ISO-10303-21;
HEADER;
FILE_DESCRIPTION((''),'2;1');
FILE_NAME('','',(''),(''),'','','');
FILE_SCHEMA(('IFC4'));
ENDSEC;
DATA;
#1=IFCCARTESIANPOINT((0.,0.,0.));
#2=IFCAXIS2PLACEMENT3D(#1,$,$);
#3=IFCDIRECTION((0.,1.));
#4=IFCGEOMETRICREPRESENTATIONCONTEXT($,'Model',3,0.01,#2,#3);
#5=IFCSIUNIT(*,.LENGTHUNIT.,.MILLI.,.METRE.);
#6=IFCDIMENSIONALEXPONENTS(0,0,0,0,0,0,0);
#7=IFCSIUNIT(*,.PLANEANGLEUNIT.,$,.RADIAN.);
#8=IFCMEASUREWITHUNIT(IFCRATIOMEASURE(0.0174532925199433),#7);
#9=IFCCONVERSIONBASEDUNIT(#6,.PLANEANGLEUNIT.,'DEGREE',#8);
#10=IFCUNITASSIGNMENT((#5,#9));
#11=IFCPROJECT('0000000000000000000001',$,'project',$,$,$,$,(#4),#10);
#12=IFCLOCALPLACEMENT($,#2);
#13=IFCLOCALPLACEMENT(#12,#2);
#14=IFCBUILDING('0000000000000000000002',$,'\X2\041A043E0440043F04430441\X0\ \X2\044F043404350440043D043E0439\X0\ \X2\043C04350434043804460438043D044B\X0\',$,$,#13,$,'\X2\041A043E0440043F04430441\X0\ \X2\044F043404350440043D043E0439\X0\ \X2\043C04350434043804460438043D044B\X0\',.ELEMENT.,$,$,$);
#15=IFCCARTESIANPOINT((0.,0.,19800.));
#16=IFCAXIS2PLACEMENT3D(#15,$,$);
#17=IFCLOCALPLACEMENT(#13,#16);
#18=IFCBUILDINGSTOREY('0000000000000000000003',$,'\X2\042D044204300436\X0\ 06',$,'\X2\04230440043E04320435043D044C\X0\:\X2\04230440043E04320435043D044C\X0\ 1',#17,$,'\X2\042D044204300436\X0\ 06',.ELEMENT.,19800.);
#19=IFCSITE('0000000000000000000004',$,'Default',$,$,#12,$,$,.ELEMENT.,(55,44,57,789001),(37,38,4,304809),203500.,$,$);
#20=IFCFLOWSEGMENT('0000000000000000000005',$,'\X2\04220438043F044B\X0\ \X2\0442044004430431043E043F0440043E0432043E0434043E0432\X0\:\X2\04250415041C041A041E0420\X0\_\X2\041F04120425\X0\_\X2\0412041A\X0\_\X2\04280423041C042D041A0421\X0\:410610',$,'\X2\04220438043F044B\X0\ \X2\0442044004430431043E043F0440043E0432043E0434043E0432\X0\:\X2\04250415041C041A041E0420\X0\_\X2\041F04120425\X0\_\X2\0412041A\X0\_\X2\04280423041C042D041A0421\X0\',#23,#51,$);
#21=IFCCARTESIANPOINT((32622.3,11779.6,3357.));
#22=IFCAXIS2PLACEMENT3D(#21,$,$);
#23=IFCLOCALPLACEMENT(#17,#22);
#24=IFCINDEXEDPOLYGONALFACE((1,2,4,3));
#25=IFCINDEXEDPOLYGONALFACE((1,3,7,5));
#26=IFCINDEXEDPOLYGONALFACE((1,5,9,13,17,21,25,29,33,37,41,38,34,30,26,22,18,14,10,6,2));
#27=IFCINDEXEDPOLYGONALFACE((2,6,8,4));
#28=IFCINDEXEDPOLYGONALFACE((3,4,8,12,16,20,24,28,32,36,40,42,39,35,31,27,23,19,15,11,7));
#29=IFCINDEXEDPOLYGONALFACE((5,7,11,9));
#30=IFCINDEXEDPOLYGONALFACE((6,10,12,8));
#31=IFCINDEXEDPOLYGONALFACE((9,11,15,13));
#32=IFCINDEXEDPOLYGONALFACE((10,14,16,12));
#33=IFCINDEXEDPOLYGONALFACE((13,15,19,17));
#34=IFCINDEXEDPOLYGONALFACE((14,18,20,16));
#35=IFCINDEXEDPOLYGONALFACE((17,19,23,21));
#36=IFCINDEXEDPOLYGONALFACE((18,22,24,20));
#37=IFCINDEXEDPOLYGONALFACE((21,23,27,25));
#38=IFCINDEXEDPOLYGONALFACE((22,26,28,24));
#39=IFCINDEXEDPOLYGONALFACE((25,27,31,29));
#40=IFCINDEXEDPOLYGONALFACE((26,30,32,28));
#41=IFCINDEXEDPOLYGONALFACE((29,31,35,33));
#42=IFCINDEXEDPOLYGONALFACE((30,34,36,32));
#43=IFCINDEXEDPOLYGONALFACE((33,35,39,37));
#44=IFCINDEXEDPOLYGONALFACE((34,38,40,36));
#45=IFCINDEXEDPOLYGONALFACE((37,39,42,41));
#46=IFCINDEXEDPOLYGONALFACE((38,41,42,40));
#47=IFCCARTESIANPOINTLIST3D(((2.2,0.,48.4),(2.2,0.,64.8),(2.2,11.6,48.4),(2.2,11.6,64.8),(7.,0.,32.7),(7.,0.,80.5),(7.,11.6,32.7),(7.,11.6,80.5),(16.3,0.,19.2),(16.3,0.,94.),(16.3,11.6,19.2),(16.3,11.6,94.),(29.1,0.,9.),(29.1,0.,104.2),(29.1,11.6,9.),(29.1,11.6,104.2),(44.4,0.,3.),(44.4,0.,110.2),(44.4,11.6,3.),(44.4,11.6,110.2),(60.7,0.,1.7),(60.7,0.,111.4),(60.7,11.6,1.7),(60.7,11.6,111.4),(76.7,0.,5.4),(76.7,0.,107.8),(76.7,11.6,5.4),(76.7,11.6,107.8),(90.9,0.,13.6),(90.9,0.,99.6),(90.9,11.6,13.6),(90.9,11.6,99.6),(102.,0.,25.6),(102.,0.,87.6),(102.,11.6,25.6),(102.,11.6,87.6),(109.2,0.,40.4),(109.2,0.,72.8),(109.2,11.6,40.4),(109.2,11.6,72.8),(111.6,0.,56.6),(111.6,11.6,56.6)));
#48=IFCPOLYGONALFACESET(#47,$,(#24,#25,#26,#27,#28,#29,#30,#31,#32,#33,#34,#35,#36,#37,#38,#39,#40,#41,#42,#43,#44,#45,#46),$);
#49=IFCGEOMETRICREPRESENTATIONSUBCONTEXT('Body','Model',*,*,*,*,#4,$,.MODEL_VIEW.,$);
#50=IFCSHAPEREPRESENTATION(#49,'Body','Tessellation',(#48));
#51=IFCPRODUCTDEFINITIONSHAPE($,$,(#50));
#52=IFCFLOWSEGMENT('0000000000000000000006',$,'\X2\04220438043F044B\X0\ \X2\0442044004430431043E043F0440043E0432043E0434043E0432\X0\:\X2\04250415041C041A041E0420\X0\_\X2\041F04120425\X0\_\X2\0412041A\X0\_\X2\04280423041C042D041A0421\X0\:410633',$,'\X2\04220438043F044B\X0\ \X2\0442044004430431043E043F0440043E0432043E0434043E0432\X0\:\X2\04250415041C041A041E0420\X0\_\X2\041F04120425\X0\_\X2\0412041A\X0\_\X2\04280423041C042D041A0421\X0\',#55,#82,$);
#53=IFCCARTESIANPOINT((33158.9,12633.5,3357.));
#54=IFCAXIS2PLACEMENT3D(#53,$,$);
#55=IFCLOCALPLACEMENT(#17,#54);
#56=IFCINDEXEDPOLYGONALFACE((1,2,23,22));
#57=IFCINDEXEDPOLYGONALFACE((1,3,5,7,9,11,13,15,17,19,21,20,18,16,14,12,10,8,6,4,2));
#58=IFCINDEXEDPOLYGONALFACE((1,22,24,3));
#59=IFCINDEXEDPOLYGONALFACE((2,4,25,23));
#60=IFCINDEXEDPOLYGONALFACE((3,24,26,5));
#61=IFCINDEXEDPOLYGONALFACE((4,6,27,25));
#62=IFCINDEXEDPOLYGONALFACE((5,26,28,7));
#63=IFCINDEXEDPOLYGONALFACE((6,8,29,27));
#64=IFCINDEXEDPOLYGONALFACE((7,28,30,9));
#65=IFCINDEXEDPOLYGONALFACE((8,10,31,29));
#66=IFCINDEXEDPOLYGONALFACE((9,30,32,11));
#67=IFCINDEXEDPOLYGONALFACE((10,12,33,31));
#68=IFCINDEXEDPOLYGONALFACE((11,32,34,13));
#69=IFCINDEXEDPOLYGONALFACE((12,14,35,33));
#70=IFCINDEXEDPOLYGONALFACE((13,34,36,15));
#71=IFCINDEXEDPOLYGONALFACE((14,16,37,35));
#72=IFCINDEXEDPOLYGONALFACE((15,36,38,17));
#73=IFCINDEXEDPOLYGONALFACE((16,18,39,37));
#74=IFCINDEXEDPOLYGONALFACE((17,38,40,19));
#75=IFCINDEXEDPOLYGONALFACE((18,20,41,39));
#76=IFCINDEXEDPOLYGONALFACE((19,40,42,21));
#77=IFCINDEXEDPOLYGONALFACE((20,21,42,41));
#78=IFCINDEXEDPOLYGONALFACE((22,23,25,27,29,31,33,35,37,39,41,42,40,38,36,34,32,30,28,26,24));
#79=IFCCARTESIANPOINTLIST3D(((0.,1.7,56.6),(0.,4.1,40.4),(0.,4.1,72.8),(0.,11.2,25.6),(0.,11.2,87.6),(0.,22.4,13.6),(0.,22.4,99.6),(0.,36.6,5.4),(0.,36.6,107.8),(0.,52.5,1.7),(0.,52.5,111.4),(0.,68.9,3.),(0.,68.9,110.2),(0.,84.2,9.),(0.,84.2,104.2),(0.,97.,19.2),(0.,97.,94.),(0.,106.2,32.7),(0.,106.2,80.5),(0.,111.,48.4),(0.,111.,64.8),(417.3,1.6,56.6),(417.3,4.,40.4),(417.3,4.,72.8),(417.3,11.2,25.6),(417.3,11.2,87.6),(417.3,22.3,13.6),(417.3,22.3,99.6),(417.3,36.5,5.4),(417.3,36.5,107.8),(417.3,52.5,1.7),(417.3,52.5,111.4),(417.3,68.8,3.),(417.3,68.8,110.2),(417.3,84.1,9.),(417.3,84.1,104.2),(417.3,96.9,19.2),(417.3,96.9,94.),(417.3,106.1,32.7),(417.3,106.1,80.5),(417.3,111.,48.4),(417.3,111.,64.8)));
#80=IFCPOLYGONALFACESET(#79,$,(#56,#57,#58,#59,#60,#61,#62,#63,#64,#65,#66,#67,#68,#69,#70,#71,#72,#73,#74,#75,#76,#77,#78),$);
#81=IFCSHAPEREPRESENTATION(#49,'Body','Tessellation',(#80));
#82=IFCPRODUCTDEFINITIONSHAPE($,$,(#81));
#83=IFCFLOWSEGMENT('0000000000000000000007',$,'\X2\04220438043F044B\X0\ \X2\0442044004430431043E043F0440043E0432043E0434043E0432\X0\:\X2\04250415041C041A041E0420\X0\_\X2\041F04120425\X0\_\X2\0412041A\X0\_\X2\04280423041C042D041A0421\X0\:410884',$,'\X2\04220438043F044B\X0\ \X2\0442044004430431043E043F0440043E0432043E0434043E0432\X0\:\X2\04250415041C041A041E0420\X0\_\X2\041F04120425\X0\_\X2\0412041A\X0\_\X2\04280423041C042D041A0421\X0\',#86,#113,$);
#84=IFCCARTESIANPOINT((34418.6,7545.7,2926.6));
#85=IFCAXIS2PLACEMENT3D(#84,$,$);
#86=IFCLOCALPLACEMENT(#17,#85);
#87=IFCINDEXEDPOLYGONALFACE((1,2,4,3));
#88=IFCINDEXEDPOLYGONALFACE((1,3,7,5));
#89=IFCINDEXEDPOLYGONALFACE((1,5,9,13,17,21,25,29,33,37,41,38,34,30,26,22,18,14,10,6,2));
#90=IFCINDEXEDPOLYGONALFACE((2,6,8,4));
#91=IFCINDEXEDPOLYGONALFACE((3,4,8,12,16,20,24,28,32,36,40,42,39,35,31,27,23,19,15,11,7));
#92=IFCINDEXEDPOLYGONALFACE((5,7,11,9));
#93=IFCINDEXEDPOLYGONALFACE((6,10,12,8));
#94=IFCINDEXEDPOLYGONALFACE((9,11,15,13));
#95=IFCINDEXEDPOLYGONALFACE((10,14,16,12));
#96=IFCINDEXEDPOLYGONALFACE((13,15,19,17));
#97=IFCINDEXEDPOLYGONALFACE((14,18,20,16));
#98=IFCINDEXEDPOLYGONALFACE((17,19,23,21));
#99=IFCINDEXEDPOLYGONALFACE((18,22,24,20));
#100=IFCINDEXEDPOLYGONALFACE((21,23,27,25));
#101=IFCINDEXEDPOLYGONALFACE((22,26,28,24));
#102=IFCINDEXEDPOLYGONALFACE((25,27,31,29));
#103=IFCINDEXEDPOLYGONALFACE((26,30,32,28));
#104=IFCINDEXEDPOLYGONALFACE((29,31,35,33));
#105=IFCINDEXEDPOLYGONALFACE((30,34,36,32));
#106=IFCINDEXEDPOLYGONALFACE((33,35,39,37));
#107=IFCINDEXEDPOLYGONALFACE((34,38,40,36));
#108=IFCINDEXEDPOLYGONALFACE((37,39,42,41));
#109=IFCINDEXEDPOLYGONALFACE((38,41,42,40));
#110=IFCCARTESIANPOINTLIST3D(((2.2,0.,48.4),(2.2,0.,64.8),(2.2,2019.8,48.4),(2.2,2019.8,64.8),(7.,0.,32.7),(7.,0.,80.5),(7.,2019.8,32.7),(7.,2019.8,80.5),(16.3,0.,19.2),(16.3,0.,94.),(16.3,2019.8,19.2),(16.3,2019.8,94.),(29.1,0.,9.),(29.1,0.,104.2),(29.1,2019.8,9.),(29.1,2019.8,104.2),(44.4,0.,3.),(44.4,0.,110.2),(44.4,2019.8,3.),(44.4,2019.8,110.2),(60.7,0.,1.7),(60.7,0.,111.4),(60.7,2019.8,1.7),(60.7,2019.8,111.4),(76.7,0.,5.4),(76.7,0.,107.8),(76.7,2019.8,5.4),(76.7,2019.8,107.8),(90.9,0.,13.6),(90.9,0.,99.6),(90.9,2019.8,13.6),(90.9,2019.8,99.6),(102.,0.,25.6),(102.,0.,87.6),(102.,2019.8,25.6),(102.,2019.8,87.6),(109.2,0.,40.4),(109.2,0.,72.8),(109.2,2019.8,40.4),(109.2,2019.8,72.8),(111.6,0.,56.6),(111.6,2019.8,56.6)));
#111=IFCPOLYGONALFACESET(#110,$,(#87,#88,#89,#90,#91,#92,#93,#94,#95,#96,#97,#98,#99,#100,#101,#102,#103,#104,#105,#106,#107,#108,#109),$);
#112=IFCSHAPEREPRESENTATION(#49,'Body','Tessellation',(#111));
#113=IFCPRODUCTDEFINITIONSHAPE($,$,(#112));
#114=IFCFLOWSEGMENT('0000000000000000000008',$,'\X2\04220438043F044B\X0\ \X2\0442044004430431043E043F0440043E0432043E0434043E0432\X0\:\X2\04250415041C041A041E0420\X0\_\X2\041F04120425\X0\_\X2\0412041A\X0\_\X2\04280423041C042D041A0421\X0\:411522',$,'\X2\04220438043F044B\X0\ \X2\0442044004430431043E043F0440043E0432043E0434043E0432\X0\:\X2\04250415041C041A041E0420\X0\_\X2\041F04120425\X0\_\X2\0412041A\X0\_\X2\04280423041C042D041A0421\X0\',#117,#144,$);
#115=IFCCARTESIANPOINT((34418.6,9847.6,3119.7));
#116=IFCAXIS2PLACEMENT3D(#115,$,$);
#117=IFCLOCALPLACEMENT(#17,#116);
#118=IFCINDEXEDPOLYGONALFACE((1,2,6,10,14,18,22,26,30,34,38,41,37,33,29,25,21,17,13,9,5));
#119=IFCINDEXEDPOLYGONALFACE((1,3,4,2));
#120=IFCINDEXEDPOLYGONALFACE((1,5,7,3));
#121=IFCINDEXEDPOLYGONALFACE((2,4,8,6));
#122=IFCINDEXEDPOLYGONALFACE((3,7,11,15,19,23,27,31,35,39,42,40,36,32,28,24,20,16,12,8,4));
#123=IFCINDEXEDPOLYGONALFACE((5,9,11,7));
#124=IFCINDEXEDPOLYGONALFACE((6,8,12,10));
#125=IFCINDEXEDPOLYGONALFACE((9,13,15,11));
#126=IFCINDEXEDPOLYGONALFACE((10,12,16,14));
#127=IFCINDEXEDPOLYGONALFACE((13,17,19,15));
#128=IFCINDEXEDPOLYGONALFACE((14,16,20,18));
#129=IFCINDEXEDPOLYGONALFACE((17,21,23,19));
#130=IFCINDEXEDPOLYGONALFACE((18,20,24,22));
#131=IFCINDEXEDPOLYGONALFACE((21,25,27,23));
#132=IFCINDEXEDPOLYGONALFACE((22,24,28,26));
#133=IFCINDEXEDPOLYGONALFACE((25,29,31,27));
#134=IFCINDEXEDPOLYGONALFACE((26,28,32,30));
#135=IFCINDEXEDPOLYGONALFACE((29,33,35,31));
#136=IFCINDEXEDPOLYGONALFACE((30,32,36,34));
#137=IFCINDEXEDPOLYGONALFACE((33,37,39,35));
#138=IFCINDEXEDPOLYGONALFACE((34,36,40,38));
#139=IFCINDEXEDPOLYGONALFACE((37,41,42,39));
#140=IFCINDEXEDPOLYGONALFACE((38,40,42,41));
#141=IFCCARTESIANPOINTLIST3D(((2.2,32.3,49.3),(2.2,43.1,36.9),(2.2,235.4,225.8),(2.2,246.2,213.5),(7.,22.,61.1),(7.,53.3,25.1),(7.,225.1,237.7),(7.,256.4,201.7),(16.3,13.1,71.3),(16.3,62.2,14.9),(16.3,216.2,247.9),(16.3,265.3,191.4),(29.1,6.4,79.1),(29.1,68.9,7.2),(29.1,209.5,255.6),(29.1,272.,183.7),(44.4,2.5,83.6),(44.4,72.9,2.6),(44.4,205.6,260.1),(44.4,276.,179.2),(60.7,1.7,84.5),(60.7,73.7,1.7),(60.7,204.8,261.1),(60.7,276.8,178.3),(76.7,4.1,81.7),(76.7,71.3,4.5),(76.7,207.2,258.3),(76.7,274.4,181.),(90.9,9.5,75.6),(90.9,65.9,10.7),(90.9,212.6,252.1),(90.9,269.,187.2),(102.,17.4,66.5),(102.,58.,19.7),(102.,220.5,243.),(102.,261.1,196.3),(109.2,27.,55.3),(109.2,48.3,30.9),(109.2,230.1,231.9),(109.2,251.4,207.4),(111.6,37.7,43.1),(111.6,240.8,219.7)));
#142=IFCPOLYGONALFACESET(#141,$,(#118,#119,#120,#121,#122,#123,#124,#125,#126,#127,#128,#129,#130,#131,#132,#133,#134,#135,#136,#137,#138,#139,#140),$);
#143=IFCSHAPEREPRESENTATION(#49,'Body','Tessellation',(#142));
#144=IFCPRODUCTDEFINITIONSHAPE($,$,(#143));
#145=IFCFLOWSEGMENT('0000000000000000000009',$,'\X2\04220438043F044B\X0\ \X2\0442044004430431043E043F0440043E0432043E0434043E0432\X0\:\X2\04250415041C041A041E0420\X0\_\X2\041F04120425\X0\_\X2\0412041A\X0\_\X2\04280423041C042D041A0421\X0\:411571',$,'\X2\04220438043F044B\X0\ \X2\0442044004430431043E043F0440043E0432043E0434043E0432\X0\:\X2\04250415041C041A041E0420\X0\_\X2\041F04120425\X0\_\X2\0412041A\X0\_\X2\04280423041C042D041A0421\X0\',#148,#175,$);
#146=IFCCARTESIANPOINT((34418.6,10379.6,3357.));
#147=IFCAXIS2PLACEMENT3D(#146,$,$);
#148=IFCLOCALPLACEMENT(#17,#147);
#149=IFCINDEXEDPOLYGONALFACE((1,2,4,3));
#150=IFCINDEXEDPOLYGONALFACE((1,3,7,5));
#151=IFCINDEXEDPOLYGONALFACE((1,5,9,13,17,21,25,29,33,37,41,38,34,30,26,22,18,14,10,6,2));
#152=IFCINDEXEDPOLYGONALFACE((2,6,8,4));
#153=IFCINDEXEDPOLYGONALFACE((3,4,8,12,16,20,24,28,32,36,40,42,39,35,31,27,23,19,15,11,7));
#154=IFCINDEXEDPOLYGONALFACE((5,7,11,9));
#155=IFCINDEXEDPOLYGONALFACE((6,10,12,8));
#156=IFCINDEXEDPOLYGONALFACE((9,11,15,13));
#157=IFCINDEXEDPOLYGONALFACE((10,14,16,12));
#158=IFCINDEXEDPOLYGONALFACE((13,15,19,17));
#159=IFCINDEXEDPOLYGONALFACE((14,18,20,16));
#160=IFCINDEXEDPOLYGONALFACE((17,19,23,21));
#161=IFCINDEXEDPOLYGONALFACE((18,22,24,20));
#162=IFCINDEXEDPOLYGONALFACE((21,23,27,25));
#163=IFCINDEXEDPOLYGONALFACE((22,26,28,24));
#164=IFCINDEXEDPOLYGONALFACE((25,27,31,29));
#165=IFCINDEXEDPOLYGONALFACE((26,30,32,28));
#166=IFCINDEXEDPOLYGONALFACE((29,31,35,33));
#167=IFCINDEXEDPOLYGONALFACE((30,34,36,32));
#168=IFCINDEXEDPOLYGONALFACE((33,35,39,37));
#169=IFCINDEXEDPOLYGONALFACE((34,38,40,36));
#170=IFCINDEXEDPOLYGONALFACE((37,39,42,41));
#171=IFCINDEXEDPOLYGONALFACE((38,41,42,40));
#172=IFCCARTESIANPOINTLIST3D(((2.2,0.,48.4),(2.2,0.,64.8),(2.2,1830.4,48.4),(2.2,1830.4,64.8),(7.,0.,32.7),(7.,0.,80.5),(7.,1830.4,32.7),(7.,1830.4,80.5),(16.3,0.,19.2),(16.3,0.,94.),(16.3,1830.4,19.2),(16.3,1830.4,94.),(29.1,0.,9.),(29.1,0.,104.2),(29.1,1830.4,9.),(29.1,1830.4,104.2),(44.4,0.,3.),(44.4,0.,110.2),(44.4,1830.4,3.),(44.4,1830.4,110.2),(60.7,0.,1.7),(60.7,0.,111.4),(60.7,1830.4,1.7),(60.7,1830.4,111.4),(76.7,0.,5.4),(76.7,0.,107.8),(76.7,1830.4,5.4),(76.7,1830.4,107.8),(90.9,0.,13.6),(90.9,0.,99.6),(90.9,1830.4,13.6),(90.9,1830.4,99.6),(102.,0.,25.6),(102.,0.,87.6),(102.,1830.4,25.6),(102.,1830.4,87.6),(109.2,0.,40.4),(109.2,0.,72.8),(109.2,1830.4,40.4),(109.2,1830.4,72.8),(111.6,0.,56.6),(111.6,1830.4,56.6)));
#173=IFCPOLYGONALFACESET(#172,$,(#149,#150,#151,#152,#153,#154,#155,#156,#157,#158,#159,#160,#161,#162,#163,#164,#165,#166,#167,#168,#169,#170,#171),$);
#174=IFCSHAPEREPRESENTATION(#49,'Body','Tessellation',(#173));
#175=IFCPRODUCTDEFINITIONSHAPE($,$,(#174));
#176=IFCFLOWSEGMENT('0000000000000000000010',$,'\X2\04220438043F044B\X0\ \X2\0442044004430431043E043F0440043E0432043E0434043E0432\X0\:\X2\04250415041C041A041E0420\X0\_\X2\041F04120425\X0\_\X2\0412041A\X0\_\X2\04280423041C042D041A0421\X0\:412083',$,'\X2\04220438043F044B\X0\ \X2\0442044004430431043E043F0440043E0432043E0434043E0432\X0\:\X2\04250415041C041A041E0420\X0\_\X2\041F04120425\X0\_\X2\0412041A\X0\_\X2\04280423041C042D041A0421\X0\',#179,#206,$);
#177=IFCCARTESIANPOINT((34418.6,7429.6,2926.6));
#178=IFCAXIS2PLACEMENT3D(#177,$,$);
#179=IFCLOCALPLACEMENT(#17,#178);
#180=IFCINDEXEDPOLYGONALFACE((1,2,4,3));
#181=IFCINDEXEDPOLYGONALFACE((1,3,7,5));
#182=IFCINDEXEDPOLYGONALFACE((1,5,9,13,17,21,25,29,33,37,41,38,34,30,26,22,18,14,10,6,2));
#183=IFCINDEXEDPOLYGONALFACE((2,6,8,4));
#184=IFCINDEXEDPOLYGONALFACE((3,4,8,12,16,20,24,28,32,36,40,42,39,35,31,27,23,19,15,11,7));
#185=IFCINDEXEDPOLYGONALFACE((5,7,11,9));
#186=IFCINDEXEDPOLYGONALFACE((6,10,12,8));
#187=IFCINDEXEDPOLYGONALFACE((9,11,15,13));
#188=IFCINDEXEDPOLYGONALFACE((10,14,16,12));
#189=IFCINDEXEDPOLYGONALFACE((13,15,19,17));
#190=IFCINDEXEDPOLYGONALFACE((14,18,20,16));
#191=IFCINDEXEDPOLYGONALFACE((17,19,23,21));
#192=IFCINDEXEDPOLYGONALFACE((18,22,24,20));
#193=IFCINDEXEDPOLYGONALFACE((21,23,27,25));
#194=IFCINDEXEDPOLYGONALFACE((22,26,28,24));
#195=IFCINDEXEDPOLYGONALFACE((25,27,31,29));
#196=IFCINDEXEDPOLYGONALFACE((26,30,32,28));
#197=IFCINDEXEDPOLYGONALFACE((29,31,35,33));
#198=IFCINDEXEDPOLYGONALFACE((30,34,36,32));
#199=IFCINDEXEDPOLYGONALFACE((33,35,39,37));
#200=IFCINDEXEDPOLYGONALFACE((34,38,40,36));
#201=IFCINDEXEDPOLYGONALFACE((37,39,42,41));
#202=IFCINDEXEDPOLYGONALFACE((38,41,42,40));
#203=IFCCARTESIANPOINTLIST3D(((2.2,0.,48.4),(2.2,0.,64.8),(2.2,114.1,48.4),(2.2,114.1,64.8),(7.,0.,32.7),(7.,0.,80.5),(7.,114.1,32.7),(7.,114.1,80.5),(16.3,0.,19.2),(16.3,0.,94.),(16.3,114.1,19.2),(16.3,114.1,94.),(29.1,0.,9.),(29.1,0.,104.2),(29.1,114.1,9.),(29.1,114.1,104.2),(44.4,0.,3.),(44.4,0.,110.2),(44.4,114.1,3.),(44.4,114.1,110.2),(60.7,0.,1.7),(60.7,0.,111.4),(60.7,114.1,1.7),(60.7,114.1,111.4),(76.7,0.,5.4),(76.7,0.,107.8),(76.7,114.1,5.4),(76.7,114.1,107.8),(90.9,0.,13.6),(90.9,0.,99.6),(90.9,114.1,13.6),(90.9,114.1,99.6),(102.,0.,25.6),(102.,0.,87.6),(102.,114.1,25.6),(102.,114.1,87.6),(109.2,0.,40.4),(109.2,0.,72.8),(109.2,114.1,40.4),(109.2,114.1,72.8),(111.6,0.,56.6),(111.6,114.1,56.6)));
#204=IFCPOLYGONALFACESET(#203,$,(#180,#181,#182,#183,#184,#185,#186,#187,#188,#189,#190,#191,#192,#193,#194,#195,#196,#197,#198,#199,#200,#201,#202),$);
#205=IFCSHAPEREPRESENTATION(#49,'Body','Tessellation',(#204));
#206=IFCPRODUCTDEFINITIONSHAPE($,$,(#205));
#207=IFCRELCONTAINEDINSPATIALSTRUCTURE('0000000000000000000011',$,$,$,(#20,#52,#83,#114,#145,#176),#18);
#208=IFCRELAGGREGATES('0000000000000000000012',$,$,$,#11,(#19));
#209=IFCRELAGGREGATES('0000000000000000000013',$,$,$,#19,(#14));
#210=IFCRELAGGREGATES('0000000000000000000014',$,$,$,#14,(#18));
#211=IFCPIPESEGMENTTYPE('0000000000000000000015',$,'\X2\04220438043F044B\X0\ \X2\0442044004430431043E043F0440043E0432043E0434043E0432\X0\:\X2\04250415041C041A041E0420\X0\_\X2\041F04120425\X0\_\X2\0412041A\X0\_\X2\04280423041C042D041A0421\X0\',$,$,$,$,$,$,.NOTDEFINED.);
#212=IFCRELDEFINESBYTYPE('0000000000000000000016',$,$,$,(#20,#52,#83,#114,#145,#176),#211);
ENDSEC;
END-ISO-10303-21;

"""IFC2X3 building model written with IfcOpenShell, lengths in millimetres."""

from ifc_helpers import new_model, entity, si_unit, converted_unit, direction, frame, origin, origin_2d_with_axis, place, context, subcontext, project, spatial, circle, extrude, type_object, element, save


model = new_model("IFC2X3")

# Units and contexts
model_context = context("Model", 3, precision=0.01, world=origin(), true_north=direction((0.0, 1.0)))
body_context = subcontext(model_context, "Body", "Model", "MODEL_VIEW")
ifc_project = project(units=[si_unit("LENGTHUNIT", "METRE", prefix="MILLI"), converted_unit("PLANEANGLEUNIT", "DEGREE", entity("IfcRatioMeasure", 0.0174532925199433), si_unit("PLANEANGLEUNIT", "RADIAN"), dimensions=[0, 0, 0, 0, 0, 0, 0])], contexts=[model_context])

# Site, building, storey
site_placement = place(None, frame((0.0, 0.0, 0.0)))
site = spatial("IfcSite", under=ifc_project, at=site_placement, Name="Default", CompositionType="ELEMENT", RefLatitude=(55, 44, 57, 789001), RefLongitude=(37, 38, 4, 304809), RefElevation=203500.0)
building_placement = place(site_placement, origin())
building = spatial("IfcBuilding", under=site, at=building_placement, Name="Корпус ядерной медицины", LongName="Корпус ядерной медицины", CompositionType="ELEMENT")
storey_placement = place(building_placement, frame((0.0, 0.0, 19800.0)))
storey = spatial("IfcBuildingStorey", under=building, at=storey_placement, Name="Этаж 06", ObjectType="Уровень:Уровень 1", LongName="Этаж 06", CompositionType="ELEMENT", Elevation=19800.0)

# Flow segments
pipe_segment_type = type_object("IfcPipeSegmentType", Name="Типы трубопроводов:ХЕМКОР_ПВХ_ВК_ШУМЭКС", PredefinedType="NOTDEFINED")
flow_segment_1_placement = place(storey_placement, frame((32622.3, 11779.6, 3357.0)))
element("IfcFlowSegment", 1, at=flow_segment_1_placement, inside=storey, type_object=pipe_segment_type, Name="Типы трубопроводов:ХЕМКОР_ПВХ_ВК_ШУМЭКС:410610", ObjectType="Типы трубопроводов:ХЕМКОР_ПВХ_ВК_ШУМЭКС", context=body_context, shape_type="SweptSolid", body=[
    extrude(circle(Radius=55.0, at=origin_2d_with_axis()), frame((56.6, 0.0, 56.6), z_axis=(0.0, 1.0, 0.0), x_axis=(1.0, 0.0, 0.0)), (0.0, 0.0, 1.0), 11.6),
])
flow_segment_2_placement = place(storey_placement, frame((33158.9, 12633.5, 3357.0)))
element("IfcFlowSegment", 2, at=flow_segment_2_placement, inside=storey, type_object=pipe_segment_type, Name="Типы трубопроводов:ХЕМКОР_ПВХ_ВК_ШУМЭКС:410633", ObjectType="Типы трубопроводов:ХЕМКОР_ПВХ_ВК_ШУМЭКС", context=body_context, shape_type="SweptSolid", body=[
    extrude(circle(Radius=55.0, at=origin_2d_with_axis()), frame((0.0, 56.7, 56.6), z_axis=(1.0, -0.000147, 0.0), x_axis=(-0.000147, -1.0, 0.0)), (0.0, 0.0, 1.0), 417.3),
])
flow_segment_3_placement = place(storey_placement, frame((34418.6, 7545.7, 2926.6)))
element("IfcFlowSegment", 3, at=flow_segment_3_placement, inside=storey, type_object=pipe_segment_type, Name="Типы трубопроводов:ХЕМКОР_ПВХ_ВК_ШУМЭКС:410884", ObjectType="Типы трубопроводов:ХЕМКОР_ПВХ_ВК_ШУМЭКС", context=body_context, shape_type="SweptSolid", body=[
    extrude(circle(Radius=55.0, at=origin_2d_with_axis()), frame((56.6, 0.0, 56.6), z_axis=(0.0, 1.0, 0.0), x_axis=(1.0, 0.0, 0.0)), (0.0, 0.0, 1.0), 2019.8),
])
flow_segment_4_placement = place(storey_placement, frame((34418.6, 9847.6, 3119.7)))
element("IfcFlowSegment", 4, at=flow_segment_4_placement, inside=storey, type_object=pipe_segment_type, Name="Типы трубопроводов:ХЕМКОР_ПВХ_ВК_ШУМЭКС:411522", ObjectType="Типы трубопроводов:ХЕМКОР_ПВХ_ВК_ШУМЭКС", context=body_context, shape_type="SweptSolid", body=[
    extrude(circle(Radius=55.0, at=origin_2d_with_axis()), frame((56.6, 37.7, 43.1), z_axis=(0.0, 0.75471, 0.656059), x_axis=(1.0, 0.0, 0.0)), (0.0, 0.0, 1.0), 269.1),
])
flow_segment_5_placement = place(storey_placement, frame((34418.6, 10379.6, 3357.0)))
element("IfcFlowSegment", 5, at=flow_segment_5_placement, inside=storey, type_object=pipe_segment_type, Name="Типы трубопроводов:ХЕМКОР_ПВХ_ВК_ШУМЭКС:411571", ObjectType="Типы трубопроводов:ХЕМКОР_ПВХ_ВК_ШУМЭКС", context=body_context, shape_type="SweptSolid", body=[
    extrude(circle(Radius=55.0, at=origin_2d_with_axis()), frame((56.6, 0.0, 56.6), z_axis=(0.0, 1.0, 0.0), x_axis=(1.0, 0.0, 0.0)), (0.0, 0.0, 1.0), 1830.4),
])
flow_segment_6_placement = place(storey_placement, frame((34418.6, 7429.6, 2926.6)))
element("IfcFlowSegment", 6, at=flow_segment_6_placement, inside=storey, type_object=pipe_segment_type, Name="Типы трубопроводов:ХЕМКОР_ПВХ_ВК_ШУМЭКС:412083", ObjectType="Типы трубопроводов:ХЕМКОР_ПВХ_ВК_ШУМЭКС", context=body_context, shape_type="SweptSolid", body=[
    extrude(circle(Radius=55.0, at=origin_2d_with_axis()), frame((56.6, 0.0, 56.6), z_axis=(0.0, 1.0, 0.0), x_axis=(1.0, 0.0, 0.0)), (0.0, 0.0, 1.0), 114.1),
])

save(model, "model.ifc")
